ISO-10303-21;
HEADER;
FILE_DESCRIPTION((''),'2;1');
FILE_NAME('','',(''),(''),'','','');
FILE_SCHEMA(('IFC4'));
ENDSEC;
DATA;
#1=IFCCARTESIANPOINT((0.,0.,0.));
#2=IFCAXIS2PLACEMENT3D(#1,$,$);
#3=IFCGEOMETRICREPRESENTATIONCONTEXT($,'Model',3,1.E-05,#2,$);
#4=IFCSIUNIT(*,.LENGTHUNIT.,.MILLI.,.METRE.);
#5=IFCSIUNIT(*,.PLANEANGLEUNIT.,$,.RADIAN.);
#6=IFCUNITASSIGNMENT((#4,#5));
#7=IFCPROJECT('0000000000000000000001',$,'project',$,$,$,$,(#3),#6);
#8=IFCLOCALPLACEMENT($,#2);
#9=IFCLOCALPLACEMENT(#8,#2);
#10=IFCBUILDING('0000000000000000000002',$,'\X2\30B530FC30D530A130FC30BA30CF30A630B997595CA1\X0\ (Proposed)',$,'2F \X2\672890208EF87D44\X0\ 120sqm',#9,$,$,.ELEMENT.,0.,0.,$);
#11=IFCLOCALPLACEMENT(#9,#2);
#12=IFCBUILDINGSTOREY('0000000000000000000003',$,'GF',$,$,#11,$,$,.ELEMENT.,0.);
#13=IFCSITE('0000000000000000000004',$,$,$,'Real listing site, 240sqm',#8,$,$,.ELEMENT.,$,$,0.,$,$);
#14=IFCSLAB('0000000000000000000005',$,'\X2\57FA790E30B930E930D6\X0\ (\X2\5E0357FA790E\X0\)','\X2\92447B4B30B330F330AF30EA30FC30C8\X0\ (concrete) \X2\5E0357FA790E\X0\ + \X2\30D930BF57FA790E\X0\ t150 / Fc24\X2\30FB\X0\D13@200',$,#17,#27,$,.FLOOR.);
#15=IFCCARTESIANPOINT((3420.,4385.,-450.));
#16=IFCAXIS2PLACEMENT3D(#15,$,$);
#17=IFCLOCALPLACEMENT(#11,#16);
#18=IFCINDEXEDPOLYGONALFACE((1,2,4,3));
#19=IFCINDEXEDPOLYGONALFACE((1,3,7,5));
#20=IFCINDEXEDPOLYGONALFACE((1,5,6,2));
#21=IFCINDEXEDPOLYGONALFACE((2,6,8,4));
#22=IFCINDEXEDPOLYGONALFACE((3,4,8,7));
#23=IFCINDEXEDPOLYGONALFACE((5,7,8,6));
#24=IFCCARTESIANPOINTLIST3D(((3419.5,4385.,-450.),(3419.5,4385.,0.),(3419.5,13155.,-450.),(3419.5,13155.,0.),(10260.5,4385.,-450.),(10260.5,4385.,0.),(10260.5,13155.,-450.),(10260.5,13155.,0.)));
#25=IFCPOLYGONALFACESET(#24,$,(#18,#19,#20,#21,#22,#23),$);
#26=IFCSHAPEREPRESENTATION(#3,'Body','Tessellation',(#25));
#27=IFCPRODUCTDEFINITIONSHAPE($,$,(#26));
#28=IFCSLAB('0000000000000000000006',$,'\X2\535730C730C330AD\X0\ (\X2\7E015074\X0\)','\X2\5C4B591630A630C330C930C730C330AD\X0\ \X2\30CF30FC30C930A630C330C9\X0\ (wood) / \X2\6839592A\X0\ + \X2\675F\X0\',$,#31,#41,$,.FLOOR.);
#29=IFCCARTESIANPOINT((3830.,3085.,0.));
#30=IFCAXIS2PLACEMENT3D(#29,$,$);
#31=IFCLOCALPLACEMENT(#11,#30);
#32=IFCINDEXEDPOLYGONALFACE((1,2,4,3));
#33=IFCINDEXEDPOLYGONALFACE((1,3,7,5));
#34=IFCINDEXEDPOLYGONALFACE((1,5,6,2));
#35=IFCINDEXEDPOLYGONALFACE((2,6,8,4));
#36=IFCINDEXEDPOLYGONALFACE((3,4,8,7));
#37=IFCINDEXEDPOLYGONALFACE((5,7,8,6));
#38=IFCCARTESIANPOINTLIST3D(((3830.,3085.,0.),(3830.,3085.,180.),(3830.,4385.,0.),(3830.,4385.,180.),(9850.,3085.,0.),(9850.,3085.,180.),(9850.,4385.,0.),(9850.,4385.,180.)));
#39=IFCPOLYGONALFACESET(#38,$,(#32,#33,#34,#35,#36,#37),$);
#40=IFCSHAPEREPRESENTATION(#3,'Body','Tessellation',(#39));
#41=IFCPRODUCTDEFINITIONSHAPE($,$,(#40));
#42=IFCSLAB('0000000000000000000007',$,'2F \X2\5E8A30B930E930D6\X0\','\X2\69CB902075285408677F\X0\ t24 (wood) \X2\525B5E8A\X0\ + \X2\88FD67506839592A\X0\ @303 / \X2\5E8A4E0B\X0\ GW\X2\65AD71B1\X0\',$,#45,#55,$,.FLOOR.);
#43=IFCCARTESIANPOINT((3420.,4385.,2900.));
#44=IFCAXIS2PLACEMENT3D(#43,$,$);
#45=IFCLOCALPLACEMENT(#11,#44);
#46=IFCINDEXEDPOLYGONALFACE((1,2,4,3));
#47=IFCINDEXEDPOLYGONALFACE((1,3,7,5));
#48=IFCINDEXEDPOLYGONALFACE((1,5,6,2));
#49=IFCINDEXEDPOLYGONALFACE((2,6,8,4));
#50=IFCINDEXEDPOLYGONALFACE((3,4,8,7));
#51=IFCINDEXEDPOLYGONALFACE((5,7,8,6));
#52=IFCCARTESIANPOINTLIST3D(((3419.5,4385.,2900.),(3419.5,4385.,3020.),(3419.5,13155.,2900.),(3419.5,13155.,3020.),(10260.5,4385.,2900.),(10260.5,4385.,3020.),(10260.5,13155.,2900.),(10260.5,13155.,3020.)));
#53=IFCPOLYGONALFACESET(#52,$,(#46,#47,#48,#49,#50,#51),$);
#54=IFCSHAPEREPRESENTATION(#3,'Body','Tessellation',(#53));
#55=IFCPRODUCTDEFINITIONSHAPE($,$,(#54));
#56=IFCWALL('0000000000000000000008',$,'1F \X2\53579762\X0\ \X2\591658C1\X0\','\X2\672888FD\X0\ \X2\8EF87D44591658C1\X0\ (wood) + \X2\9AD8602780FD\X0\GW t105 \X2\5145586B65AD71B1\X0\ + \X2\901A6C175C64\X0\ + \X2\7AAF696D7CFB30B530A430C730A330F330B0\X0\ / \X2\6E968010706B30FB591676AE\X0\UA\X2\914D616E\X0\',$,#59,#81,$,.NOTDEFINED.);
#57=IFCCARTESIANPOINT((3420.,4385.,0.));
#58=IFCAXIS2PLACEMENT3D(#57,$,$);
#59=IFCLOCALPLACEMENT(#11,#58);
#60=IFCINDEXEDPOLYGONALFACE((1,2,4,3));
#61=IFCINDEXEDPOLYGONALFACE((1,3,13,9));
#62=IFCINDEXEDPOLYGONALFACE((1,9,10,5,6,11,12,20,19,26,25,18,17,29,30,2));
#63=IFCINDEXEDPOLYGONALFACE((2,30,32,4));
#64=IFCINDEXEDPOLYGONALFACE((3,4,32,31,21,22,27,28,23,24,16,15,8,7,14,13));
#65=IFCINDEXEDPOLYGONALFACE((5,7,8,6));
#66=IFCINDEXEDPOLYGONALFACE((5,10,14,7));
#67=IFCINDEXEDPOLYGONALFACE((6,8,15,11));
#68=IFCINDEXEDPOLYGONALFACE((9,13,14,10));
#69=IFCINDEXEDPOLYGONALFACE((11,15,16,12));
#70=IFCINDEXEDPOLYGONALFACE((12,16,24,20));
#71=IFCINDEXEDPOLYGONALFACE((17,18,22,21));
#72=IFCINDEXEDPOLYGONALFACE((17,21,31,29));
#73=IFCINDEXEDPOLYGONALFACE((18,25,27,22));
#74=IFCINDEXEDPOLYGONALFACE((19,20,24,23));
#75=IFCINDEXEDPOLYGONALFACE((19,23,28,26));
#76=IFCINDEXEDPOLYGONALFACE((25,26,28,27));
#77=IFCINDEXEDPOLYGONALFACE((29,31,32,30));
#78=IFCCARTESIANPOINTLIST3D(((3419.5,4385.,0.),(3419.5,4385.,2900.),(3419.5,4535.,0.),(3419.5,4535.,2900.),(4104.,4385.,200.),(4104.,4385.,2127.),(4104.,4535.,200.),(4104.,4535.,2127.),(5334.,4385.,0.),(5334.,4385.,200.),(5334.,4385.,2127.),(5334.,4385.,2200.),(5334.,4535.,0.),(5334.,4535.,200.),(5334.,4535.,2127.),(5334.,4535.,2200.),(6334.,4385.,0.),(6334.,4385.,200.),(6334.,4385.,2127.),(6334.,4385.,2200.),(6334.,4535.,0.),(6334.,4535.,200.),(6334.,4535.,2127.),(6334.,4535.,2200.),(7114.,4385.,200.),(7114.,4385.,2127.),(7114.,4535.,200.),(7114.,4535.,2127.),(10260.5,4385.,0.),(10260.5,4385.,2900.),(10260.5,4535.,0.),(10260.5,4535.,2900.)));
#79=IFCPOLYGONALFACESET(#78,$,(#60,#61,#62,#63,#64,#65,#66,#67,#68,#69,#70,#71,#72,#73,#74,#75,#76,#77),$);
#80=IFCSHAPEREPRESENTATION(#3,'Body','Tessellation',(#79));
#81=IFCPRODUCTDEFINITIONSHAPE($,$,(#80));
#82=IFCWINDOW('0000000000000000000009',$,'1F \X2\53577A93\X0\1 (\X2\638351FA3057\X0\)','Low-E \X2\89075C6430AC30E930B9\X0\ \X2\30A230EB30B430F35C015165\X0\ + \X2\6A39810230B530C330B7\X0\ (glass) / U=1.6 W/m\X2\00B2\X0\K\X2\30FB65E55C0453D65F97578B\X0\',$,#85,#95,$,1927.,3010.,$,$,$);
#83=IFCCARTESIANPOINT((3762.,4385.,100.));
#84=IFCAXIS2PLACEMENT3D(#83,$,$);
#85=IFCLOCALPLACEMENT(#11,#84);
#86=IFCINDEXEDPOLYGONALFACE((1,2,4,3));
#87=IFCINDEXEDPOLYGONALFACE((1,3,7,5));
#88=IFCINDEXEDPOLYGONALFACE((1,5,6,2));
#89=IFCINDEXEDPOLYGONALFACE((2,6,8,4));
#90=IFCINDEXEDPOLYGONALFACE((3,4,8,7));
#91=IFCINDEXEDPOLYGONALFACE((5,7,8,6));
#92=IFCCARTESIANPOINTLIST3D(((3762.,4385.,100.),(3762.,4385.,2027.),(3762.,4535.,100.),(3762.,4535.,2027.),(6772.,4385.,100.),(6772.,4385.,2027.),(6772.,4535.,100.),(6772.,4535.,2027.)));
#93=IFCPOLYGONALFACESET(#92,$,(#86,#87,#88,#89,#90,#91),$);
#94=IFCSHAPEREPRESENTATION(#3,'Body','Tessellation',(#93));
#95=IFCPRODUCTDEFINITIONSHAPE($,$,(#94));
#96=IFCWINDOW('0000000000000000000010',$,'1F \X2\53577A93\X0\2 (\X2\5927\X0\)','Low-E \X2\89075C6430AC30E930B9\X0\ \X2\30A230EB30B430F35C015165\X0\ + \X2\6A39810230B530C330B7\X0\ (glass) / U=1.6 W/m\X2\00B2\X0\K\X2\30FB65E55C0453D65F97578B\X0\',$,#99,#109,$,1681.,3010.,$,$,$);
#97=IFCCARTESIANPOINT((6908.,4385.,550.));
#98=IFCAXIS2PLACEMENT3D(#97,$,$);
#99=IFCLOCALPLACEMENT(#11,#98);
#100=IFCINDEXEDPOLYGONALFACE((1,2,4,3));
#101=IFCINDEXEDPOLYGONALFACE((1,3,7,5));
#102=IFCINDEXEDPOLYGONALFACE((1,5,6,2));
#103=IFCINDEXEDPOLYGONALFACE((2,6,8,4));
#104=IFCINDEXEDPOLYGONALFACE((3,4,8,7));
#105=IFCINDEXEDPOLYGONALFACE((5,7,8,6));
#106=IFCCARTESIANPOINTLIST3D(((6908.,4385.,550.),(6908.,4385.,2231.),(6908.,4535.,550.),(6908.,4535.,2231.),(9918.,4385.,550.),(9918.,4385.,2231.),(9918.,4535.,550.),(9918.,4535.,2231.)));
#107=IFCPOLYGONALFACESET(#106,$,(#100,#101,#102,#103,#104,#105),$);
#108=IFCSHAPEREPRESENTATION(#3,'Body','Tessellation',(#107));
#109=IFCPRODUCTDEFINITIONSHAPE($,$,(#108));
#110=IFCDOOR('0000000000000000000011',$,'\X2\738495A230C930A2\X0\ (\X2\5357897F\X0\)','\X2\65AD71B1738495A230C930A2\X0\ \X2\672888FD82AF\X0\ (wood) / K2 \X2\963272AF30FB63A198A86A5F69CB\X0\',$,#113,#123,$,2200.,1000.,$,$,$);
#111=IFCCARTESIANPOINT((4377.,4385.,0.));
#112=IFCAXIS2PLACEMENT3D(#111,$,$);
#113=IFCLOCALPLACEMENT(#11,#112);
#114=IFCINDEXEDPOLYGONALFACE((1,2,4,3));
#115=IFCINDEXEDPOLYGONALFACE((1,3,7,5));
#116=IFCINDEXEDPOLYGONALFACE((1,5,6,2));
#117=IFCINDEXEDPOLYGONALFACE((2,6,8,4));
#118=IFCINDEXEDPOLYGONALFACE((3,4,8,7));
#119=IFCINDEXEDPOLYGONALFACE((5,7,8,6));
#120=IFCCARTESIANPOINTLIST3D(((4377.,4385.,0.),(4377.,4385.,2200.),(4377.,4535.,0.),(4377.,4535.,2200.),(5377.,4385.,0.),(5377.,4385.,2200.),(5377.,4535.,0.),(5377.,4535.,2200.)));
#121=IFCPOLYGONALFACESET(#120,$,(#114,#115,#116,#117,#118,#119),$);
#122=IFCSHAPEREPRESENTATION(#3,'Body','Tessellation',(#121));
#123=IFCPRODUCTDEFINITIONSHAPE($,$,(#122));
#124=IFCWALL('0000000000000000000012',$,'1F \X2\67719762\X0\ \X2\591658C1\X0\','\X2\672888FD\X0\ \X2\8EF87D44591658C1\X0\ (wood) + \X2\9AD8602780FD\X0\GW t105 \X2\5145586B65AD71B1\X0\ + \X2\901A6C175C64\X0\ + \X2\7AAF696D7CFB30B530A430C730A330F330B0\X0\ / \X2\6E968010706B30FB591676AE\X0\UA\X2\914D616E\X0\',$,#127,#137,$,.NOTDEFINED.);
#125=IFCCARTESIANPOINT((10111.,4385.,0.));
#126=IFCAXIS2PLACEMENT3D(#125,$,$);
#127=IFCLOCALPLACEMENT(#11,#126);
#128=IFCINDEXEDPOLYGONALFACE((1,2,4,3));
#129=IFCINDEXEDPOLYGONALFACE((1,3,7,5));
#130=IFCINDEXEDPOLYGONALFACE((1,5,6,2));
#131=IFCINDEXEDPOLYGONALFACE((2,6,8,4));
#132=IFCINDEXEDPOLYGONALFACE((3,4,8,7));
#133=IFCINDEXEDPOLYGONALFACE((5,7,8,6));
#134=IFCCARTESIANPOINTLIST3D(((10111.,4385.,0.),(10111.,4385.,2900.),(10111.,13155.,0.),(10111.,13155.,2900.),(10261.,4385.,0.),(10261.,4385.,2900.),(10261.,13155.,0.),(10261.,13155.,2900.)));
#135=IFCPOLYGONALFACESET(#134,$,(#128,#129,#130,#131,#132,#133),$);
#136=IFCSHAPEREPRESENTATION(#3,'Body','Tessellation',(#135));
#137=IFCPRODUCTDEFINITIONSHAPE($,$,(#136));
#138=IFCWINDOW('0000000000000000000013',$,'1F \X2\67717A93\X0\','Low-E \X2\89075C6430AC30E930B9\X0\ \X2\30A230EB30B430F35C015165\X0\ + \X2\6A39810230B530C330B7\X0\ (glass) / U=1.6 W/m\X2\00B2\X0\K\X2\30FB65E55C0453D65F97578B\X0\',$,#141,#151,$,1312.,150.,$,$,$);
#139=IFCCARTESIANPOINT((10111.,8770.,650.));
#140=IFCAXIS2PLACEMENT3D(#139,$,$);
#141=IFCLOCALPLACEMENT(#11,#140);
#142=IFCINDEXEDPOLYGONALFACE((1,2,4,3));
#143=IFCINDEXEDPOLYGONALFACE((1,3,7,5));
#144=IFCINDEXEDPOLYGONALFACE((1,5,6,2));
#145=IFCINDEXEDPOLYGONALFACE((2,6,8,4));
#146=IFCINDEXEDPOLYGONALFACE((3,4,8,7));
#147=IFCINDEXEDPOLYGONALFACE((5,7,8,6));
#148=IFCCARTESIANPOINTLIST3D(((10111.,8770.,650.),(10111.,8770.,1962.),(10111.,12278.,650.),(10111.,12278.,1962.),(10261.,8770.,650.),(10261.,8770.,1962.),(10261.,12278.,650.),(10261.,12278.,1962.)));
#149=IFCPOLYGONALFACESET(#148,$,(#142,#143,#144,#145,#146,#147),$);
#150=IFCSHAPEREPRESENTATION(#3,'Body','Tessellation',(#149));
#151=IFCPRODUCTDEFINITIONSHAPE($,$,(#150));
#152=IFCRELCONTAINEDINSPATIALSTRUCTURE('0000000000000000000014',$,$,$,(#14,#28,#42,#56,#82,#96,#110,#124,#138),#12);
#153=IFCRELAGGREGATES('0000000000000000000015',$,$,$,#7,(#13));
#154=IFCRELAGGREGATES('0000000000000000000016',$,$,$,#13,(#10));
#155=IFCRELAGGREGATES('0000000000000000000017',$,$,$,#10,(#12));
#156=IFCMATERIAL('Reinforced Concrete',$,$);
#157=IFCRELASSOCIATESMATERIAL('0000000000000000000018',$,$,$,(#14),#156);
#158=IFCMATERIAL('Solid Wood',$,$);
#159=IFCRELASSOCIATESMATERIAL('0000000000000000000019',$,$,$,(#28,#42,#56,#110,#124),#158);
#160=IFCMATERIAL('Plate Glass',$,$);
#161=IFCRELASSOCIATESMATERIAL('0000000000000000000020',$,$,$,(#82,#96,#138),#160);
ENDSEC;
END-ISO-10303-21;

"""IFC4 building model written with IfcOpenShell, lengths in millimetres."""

from ifc_helpers import new_model, si_unit, frame, frame_2d, origin, place, context, project, spatial, rectangle, extrude, material, element, fill, save


model = new_model("IFC4")

# Units and contexts
model_context = context("Model", 3, precision=1e-05, world=origin())
ifc_project = project(units=[si_unit("LENGTHUNIT", "METRE", prefix="MILLI"), si_unit("PLANEANGLEUNIT", "RADIAN")], contexts=[model_context])

# Site, building, storey
site_placement = place(None, origin())
site = spatial("IfcSite", under=ifc_project, at=site_placement, ObjectType="Real listing site, 240sqm", CompositionType="ELEMENT", RefElevation=0.0)
building_placement = place(site_placement, origin())
building = spatial("IfcBuilding", under=site, at=building_placement, Name="サーファーズハウス静岡 (Proposed)", ObjectType="2F 木造軸組 120sqm", CompositionType="ELEMENT", ElevationOfRefHeight=0.0, ElevationOfTerrain=0.0)
storey_placement = place(building_placement, origin())
storey = spatial("IfcBuildingStorey", under=building, at=storey_placement, Name="GF", CompositionType="ELEMENT", Elevation=0.0)

# Slabs
ifc_material_1 = material(Name="Reinforced Concrete")
slab_1_placement = place(storey_placement, frame((3420.0, 4385.0, -450.0)))
element("IfcSlab", 1, at=slab_1_placement, inside=storey, material=ifc_material_1, Name="基礎スラブ (布基礎)", Description="鉄筋コンクリート (concrete) 布基礎 + ベタ基礎 t150 / Fc24・D13@200", PredefinedType="FLOOR", context=model_context, shape_type="SweptSolid", body=[
    extrude(rectangle(XDim=6841.0, YDim=8770.0, at=frame_2d((3420.0, 4385.0))), frame((3420.0, 4385.0, -450.0)), (0.0, 0.0, 1.0), 450.0),
])
ifc_material_2 = material(Name="Solid Wood")
slab_2_placement = place(storey_placement, frame((3830.0, 3085.0, 0.0)))
element("IfcSlab", 2, at=slab_2_placement, inside=storey, material=ifc_material_2, Name="南デッキ (縁側)", Description="屋外ウッドデッキ ハードウッド (wood) / 根太 + 束", PredefinedType="FLOOR", context=model_context, shape_type="SweptSolid", body=[
    extrude(rectangle(XDim=6020.0, YDim=1300.0, at=frame_2d((3010.0, 650.0))), frame((3830.0, 3085.0, 0.0)), (0.0, 0.0, 1.0), 180.0),
])
slab_3_placement = place(storey_placement, frame((3420.0, 4385.0, 2900.0)))
element("IfcSlab", 3, at=slab_3_placement, inside=storey, material=ifc_material_2, Name="2F 床スラブ", Description="構造用合板 t24 (wood) 剛床 + 製材根太 @303 / 床下 GW断熱", PredefinedType="FLOOR", context=model_context, shape_type="SweptSolid", body=[
    extrude(rectangle(XDim=6841.0, YDim=8770.0, at=frame_2d((3420.0, 4385.0))), frame((3420.0, 4385.0, 2900.0)), (0.0, 0.0, 1.0), 120.0),
])

# Wall, openings, windows, door
wall_1_placement = place(storey_placement, frame((3420.0, 4385.0, 0.0)))
wall_1 = element("IfcWall", 4, at=wall_1_placement, inside=storey, material=ifc_material_2, Name="1F 南面 外壁", Description="木製 軸組外壁 (wood) + 高性能GW t105 充填断熱 + 通気層 + 窯業系サイディング / 準耐火・外皮UA配慮", PredefinedType="NOTDEFINED", context=model_context, shape_type="SweptSolid", body=[
    extrude(rectangle(XDim=6841.0, YDim=150.0, at=frame_2d((3420.0, 75.0))), frame((3420.0, 4385.0, 0.0)), (0.0, 0.0, 1.0), 2900.0),
])
opening_1_placement = place(storey_placement, frame((3762.0, 4385.0, 100.0)))
opening_1 = element("IfcOpeningElement", 5, at=opening_1_placement, cuts=wall_1, PredefinedType="NOTDEFINED", context=model_context, shape_type="SweptSolid", body=[
    extrude(rectangle(XDim=3010.0, YDim=150.0, at=frame_2d((1505.0, 75.0))), frame((3762.0, 4385.0, 100.0)), (0.0, 0.0, 1.0), 1927.0),
])
opening_2_placement = place(storey_placement, frame((6908.0, 4385.0, 550.0)))
opening_2 = element("IfcOpeningElement", 6, at=opening_2_placement, cuts=wall_1, PredefinedType="NOTDEFINED", context=model_context, shape_type="SweptSolid", body=[
    extrude(rectangle(XDim=3010.0, YDim=150.0, at=frame_2d((1505.0, 75.0))), frame((6908.0, 4385.0, 550.0)), (0.0, 0.0, 1.0), 1681.0),
])
opening_3_placement = place(storey_placement, frame((4377.0, 4385.0, 0.0)))
opening_3 = element("IfcOpeningElement", 7, at=opening_3_placement, cuts=wall_1, PredefinedType="NOTDEFINED", context=model_context, shape_type="SweptSolid", body=[
    extrude(rectangle(XDim=1000.0, YDim=150.0, at=frame_2d((500.0, 75.0))), frame((4377.0, 4385.0, 0.0)), (0.0, 0.0, 1.0), 2200.0),
])
ifc_material_3 = material(Name="Plate Glass")
window_1_placement = place(storey_placement, frame((3762.0, 4385.0, 100.0)))
window_1 = element("IfcWindow", 8, at=window_1_placement, inside=storey, material=ifc_material_3, Name="1F 南窓1 (掃出し)", Description="Low-E 複層ガラス アルゴン封入 + 樹脂サッシ (glass) / U=1.6 W/m²K・日射取得型", OverallHeight=1927.0, OverallWidth=3010.0, context=model_context, shape_type="SweptSolid", body=[
    extrude(rectangle(XDim=3010.0, YDim=150.0, at=frame_2d((1505.0, 75.0))), frame((3762.0, 4385.0, 100.0)), (0.0, 0.0, 1.0), 1927.0),
])
fill(opening_1, window_1)
window_2_placement = place(storey_placement, frame((6908.0, 4385.0, 550.0)))
window_2 = element("IfcWindow", 9, at=window_2_placement, inside=storey, material=ifc_material_3, Name="1F 南窓2 (大)", Description="Low-E 複層ガラス アルゴン封入 + 樹脂サッシ (glass) / U=1.6 W/m²K・日射取得型", OverallHeight=1681.0, OverallWidth=3010.0, context=model_context, shape_type="SweptSolid", body=[
    extrude(rectangle(XDim=3010.0, YDim=150.0, at=frame_2d((1505.0, 75.0))), frame((6908.0, 4385.0, 550.0)), (0.0, 0.0, 1.0), 1681.0),
])
fill(opening_2, window_2)
door_placement = place(storey_placement, frame((4377.0, 4385.0, 0.0)))
door = element("IfcDoor", 10, at=door_placement, inside=storey, material=ifc_material_2, Name="玄関ドア (南西)", Description="断熱玄関ドア 木製芯 (wood) / K2 防犯・採風機構", OverallHeight=2200.0, OverallWidth=1000.0, context=model_context, shape_type="SweptSolid", body=[
    extrude(rectangle(XDim=1000.0, YDim=150.0, at=frame_2d((500.0, 75.0))), frame((4377.0, 4385.0, 0.0)), (0.0, 0.0, 1.0), 2200.0),
])
fill(opening_3, door)

# Wall, opening, window
wall_2_placement = place(storey_placement, frame((10111.0, 4385.0, 0.0)))
wall_2 = element("IfcWall", 11, at=wall_2_placement, inside=storey, material=ifc_material_2, Name="1F 東面 外壁", Description="木製 軸組外壁 (wood) + 高性能GW t105 充填断熱 + 通気層 + 窯業系サイディング / 準耐火・外皮UA配慮", PredefinedType="NOTDEFINED", context=model_context, shape_type="SweptSolid", body=[
    extrude(rectangle(XDim=150.0, YDim=8770.0, at=frame_2d((75.0, 4385.0))), frame((10111.0, 4385.0, 0.0)), (0.0, 0.0, 1.0), 2900.0),
])
opening_4_placement = place(storey_placement, frame((10111.0, 8770.0, 650.0)))
opening_4 = element("IfcOpeningElement", 12, at=opening_4_placement, cuts=wall_2, PredefinedType="NOTDEFINED", context=model_context, shape_type="SweptSolid", body=[
    extrude(rectangle(XDim=150.0, YDim=3508.0, at=frame_2d((75.0, 1754.0))), frame((10111.0, 8770.0, 650.0)), (0.0, 0.0, 1.0), 1312.0),
])
window_3_placement = place(storey_placement, frame((10111.0, 8770.0, 650.0)))
window_3 = element("IfcWindow", 13, at=window_3_placement, inside=storey, material=ifc_material_3, Name="1F 東窓", Description="Low-E 複層ガラス アルゴン封入 + 樹脂サッシ (glass) / U=1.6 W/m²K・日射取得型", OverallHeight=1312.0, OverallWidth=150.0, context=model_context, shape_type="SweptSolid", body=[
    extrude(rectangle(XDim=150.0, YDim=3508.0, at=frame_2d((75.0, 1754.0))), frame((10111.0, 8770.0, 650.0)), (0.0, 0.0, 1.0), 1312.0),
])
fill(opening_4, window_3)

save(model, "model.ifc")
